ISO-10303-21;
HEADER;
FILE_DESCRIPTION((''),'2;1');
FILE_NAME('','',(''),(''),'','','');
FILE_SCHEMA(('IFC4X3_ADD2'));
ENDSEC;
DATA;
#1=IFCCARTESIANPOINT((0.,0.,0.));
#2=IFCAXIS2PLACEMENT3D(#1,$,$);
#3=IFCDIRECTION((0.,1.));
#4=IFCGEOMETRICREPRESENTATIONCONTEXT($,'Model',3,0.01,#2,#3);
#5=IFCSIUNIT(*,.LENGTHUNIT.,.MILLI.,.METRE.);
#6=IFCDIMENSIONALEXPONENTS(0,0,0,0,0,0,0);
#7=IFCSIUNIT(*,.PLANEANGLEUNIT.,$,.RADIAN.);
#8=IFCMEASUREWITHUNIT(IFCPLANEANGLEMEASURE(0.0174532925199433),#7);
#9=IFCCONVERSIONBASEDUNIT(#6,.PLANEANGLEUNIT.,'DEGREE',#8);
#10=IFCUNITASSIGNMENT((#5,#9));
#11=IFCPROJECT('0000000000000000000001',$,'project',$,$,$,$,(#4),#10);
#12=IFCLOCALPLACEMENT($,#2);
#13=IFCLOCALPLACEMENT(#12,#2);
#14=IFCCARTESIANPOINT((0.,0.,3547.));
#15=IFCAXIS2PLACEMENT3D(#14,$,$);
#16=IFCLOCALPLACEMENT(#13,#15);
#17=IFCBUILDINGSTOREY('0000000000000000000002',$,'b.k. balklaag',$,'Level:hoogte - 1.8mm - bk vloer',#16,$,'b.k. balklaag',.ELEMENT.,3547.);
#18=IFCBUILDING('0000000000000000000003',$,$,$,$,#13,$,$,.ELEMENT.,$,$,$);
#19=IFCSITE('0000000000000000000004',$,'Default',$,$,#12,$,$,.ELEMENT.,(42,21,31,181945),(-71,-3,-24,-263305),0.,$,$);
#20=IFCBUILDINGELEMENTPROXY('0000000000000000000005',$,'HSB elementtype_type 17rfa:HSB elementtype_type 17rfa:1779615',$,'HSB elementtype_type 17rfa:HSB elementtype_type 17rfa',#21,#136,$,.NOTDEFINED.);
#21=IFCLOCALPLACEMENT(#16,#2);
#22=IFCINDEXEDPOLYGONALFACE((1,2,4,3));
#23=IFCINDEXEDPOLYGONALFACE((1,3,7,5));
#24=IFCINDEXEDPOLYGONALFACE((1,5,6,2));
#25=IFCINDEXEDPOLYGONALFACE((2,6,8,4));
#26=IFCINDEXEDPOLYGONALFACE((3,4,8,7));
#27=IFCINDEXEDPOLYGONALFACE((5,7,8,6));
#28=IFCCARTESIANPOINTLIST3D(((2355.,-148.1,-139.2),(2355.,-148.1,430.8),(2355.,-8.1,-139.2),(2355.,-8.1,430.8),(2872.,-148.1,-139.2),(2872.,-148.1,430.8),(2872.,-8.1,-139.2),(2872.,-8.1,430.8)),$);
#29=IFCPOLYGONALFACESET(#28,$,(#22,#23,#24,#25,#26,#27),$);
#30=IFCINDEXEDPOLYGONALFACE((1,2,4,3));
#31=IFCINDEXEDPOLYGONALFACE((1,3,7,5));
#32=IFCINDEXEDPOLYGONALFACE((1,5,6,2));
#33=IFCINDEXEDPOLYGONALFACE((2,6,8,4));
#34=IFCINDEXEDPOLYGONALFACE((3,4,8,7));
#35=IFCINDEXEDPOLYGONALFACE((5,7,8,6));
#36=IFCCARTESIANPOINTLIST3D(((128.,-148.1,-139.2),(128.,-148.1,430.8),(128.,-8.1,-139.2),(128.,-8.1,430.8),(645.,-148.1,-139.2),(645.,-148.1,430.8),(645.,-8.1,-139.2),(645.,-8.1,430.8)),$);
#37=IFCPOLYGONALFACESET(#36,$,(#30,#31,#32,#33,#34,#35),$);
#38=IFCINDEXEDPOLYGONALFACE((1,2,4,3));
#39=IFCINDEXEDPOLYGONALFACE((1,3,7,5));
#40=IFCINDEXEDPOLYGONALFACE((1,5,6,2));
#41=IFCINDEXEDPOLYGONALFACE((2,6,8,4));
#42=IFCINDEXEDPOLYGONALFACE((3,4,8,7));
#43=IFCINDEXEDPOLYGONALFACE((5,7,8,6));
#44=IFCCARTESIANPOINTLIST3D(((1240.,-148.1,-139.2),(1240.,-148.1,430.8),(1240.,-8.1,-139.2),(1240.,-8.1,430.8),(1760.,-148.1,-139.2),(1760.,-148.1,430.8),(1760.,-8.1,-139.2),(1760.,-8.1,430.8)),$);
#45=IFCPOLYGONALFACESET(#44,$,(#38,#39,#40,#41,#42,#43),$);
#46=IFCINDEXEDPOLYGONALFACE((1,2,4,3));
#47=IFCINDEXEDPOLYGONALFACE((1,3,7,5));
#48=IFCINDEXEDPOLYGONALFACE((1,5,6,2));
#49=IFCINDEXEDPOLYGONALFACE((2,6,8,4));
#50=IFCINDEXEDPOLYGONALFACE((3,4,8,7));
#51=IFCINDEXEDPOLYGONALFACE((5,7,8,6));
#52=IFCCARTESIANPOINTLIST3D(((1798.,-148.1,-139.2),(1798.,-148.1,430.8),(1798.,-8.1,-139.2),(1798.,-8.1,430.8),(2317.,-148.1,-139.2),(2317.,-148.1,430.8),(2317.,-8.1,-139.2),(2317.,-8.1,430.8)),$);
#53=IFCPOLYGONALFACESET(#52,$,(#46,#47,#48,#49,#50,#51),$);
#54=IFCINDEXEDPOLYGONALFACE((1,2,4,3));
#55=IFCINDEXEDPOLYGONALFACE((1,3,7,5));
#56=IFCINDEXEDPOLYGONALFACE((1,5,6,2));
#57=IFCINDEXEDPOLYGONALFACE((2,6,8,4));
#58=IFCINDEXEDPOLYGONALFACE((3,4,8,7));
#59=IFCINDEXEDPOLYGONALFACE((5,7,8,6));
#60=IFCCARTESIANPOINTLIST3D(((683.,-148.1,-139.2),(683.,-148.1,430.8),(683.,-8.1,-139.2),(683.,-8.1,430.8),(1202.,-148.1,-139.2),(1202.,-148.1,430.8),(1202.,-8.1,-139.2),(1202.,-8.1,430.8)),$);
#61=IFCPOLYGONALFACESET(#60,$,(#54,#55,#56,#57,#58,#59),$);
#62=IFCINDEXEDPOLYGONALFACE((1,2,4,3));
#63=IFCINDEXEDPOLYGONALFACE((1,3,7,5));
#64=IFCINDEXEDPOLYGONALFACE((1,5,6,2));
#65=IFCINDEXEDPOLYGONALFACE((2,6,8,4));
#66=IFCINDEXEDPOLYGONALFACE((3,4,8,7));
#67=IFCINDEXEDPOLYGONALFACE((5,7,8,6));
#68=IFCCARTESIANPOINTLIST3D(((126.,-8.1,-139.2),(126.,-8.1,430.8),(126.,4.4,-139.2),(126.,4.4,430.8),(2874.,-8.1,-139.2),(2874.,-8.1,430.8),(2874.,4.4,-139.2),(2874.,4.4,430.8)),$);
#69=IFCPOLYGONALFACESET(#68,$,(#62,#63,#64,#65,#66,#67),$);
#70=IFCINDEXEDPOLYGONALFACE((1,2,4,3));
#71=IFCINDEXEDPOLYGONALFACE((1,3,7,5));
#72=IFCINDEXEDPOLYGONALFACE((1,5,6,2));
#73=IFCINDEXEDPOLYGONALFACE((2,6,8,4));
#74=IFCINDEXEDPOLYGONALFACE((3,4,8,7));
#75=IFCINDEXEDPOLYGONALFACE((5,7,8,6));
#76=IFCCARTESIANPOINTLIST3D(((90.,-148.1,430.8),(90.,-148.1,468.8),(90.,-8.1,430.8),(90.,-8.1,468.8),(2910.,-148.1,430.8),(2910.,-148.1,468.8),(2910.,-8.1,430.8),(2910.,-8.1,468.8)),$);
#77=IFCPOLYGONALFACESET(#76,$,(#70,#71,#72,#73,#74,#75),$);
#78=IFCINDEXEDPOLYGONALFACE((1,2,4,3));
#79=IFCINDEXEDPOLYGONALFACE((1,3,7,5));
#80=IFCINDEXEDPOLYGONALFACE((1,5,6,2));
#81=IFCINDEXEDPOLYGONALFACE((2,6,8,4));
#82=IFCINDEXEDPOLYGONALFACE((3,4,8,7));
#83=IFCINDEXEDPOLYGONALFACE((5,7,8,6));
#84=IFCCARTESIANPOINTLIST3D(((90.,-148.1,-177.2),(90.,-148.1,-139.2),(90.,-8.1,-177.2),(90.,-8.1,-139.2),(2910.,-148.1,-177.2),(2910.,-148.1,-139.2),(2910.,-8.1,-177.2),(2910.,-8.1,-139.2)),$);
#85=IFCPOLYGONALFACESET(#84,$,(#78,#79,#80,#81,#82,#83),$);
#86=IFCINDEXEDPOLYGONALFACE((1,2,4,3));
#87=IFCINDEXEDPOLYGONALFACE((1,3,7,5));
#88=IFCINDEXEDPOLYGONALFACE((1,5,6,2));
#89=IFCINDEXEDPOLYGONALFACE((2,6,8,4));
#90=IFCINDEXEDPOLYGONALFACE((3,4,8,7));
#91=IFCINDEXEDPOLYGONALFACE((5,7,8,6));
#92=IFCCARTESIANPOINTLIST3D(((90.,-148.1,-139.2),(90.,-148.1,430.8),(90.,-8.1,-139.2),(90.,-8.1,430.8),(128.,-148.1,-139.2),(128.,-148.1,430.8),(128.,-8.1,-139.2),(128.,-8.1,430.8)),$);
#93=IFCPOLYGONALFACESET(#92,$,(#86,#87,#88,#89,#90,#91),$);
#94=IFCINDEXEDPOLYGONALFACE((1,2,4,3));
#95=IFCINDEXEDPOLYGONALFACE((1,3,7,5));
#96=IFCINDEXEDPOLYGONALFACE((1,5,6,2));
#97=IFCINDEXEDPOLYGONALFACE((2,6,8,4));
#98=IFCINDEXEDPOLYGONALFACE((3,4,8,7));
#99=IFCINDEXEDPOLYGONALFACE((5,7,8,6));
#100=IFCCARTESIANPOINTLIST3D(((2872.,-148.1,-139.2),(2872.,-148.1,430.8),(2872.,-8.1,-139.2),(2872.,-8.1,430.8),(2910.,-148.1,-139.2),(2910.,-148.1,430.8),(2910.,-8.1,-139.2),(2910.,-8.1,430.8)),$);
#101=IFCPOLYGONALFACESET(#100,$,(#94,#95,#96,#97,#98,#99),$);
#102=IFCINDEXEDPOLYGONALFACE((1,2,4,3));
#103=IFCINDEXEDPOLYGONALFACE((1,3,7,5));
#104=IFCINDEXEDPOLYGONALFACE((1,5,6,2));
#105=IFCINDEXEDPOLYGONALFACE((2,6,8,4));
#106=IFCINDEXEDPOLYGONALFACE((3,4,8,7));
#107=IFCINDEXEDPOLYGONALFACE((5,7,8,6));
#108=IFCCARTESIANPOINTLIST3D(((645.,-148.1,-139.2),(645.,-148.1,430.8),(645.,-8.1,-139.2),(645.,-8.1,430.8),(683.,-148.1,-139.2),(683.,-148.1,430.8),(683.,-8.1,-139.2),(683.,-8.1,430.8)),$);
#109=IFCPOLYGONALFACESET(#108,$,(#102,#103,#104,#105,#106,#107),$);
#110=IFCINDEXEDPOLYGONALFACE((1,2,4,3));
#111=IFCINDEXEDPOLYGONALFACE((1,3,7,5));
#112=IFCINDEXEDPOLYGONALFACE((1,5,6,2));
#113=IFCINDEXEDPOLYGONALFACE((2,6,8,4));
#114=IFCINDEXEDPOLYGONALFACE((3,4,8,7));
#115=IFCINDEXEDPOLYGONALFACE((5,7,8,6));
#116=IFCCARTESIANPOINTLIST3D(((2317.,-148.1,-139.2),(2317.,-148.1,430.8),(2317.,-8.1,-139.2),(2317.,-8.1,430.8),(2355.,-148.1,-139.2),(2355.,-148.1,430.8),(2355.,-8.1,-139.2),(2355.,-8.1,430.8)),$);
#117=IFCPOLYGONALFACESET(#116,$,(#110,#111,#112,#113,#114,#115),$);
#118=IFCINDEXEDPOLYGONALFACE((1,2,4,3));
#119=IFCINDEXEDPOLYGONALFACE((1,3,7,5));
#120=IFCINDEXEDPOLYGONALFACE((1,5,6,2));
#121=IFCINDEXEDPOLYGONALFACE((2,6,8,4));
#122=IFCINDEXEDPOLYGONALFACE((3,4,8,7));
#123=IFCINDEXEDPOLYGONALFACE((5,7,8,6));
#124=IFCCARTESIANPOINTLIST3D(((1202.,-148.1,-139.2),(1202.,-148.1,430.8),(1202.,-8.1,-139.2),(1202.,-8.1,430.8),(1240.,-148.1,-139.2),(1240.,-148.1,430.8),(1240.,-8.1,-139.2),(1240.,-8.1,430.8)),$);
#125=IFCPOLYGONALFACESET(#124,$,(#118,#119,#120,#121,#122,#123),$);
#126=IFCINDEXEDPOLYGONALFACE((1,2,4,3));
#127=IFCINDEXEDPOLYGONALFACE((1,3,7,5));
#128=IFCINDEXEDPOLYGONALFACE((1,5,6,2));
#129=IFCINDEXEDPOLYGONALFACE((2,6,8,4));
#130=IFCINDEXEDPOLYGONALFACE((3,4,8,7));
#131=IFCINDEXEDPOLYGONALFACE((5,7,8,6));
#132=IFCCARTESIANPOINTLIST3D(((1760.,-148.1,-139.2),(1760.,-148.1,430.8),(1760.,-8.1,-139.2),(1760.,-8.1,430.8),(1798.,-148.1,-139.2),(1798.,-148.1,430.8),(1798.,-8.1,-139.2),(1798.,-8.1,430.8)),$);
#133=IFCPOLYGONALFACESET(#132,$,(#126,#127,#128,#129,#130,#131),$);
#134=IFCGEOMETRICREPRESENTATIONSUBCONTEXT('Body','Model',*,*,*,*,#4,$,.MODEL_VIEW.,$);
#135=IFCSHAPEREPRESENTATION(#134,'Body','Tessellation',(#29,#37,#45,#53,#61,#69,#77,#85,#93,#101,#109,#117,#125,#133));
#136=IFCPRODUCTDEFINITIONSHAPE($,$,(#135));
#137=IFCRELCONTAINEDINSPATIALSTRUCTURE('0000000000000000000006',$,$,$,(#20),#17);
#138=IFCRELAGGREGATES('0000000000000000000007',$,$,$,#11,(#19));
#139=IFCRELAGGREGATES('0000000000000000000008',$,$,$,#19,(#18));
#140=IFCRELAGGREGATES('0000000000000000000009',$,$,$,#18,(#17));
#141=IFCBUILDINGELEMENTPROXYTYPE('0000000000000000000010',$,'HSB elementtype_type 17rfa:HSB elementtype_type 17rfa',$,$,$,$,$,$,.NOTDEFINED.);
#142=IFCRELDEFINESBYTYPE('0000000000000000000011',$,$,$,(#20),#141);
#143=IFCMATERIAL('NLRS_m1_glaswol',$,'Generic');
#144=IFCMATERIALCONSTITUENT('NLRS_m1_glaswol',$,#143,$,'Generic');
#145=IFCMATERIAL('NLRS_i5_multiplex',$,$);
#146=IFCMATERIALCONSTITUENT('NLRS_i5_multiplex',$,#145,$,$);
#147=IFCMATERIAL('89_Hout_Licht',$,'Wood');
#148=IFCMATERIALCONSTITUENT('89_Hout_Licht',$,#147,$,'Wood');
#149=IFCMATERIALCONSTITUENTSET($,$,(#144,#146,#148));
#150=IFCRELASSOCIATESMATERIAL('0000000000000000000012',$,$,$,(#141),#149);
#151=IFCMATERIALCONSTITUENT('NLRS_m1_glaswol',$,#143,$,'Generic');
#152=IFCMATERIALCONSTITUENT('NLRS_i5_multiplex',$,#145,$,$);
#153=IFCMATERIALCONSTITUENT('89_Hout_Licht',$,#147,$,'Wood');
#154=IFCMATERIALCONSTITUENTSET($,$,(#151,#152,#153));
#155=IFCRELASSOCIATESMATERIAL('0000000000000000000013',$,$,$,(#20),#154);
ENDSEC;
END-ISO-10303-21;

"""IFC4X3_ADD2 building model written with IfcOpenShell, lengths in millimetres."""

from ifc_helpers import new_model, entity, si_unit, converted_unit, direction, frame, frame_2d, origin, origin_2d_with_axis, place, context, subcontext, project, spatial, rectangle, extrude, source, transform, mapped, material, constituent, constituent_set, type_object, type_shapes, element, save


model = new_model("IFC4X3_ADD2")

# Units and contexts
model_context = context("Model", 3, precision=0.01, world=origin(), true_north=direction((0.0, 1.0)))
body_context = subcontext(model_context, "Body", "Model", "MODEL_VIEW")
ifc_project = project(units=[si_unit("LENGTHUNIT", "METRE", prefix="MILLI"), converted_unit("PLANEANGLEUNIT", "DEGREE", entity("IfcPlaneAngleMeasure", 0.0174532925199433), si_unit("PLANEANGLEUNIT", "RADIAN"), dimensions=[0, 0, 0, 0, 0, 0, 0])], contexts=[model_context])

# Site, building, storey
site_placement = place(None, origin())
site = spatial("IfcSite", under=ifc_project, at=site_placement, Name="Default", CompositionType="ELEMENT", RefLatitude=(42, 21, 31, 181945), RefLongitude=(-71, -3, -24, -263305), RefElevation=0.0)
building_placement = place(site_placement, origin())
building = spatial("IfcBuilding", under=site, at=building_placement, CompositionType="ELEMENT")
storey_placement = place(building_placement, frame((0.0, 0.0, 3547.0)))
storey = spatial("IfcBuildingStorey", under=building, at=storey_placement, Name="b.k. balklaag", ObjectType="Level:hoogte - 1.8mm - bk vloer", LongName="b.k. balklaag", CompositionType="ELEMENT", Elevation=3547.0)

# Shared definitions
ifc_material_1 = material(Name="89_Hout_Licht", Category="Wood")

# Building element proxy
ifc_material_2 = material(Name="NLRS_m1_glaswol", Category="Generic")
ifc_material_3 = material(Name="NLRS_i5_multiplex")
ifc_constituent_1 = constituent(ifc_material_2, Name="NLRS_m1_glaswol", Category="Generic")
ifc_constituent_2 = constituent(ifc_material_3, Name="NLRS_i5_multiplex")
ifc_constituent_3 = constituent(ifc_material_1, Name="89_Hout_Licht", Category="Wood")
ifc_constituent_set_1 = constituent_set(constituents=[ifc_constituent_1, ifc_constituent_2, ifc_constituent_3])
ifc_constituent_4 = constituent(ifc_material_2, Name="NLRS_m1_glaswol", Category="Generic")
ifc_constituent_5 = constituent(ifc_material_3, Name="NLRS_i5_multiplex")
ifc_constituent_6 = constituent(ifc_material_1, Name="89_Hout_Licht", Category="Wood")
ifc_constituent_set_2 = constituent_set(constituents=[ifc_constituent_4, ifc_constituent_5, ifc_constituent_6])
building_element_proxy_type_1 = type_object("IfcBuildingElementProxyType", Name="HSB elementtype_type 17rfa:HSB elementtype_type 17rfa", PredefinedType="NOTDEFINED", material=ifc_constituent_set_2)
shared_shape_1 = source(origin(), body_context, "Body", "SweptSolid", [
    extrude(rectangle(XDim=517.0, YDim=140.0, at=frame_2d((0.0, 0.0), x_axis=(1.0, 0.0))), frame((-1149.5, 70.0, 38.0), z_axis=(0.0, 0.0, 1.0), x_axis=(-1.0, 0.0, 0.0)), (0.0, 0.0, 1.0), 570.0),
    extrude(rectangle(XDim=517.0, YDim=140.0, at=frame_2d((0.0, 0.0), x_axis=(1.0, 0.0))), frame((1077.5, 70.0, 38.0), z_axis=(0.0, 0.0, 1.0), x_axis=(-1.0, 0.0, 0.0)), (0.0, 0.0, 1.0), 570.0),
    extrude(rectangle(XDim=520.0, YDim=140.0, at=origin_2d_with_axis()), frame((-36.0, 70.0, 38.0), z_axis=(0.0, 0.0, 1.0), x_axis=(-1.0, 0.0, 0.0)), (0.0, 0.0, 1.0), 570.0),
    extrude(rectangle(XDim=519.0, YDim=140.0, at=origin_2d_with_axis()), frame((-593.5, 70.0, 38.0), z_axis=(0.0, 0.0, 1.0), x_axis=(-1.0, 0.0, 0.0)), (0.0, 0.0, 1.0), 570.0),
    extrude(rectangle(XDim=519.0, YDim=140.0, at=origin_2d_with_axis()), frame((521.5, 70.0, 38.0), z_axis=(0.0, 0.0, 1.0), x_axis=(-1.0, 0.0, 0.0)), (0.0, 0.0, 1.0), 570.0),
    extrude(rectangle(XDim=2748.0, YDim=12.5, at=frame_2d((0.0, 0.0), x_axis=(1.0, 0.0))), frame((-36.0, -6.2, 38.0), z_axis=(0.0, 0.0, 1.0), x_axis=(-1.0, 0.0, 0.0)), (0.0, 0.0, 1.0), 570.0),
    extrude(rectangle(XDim=2820.0, YDim=140.0, at=frame_2d((0.0, 0.0), x_axis=(1.0, 0.0))), frame((-36.0, 70.0, 608.0), z_axis=(0.0, 0.0, 1.0), x_axis=(-1.0, 0.0, 0.0)), (0.0, 0.0, 1.0), 38.0),
    extrude(rectangle(XDim=2820.0, YDim=140.0, at=origin_2d_with_axis()), frame((-36.0, 70.0, 0.0), z_axis=(0.0, 0.0, 1.0), x_axis=(-1.0, 0.0, 0.0)), (0.0, 0.0, 1.0), 38.0),
    extrude(rectangle(XDim=38.0, YDim=140.0, at=frame_2d((0.0, 0.0), x_axis=(1.0, 0.0))), frame((1355.0, 70.0, 38.0), z_axis=(0.0, 0.0, 1.0), x_axis=(-1.0, 0.0, 0.0)), (0.0, 0.0, 1.0), 570.0),
    extrude(rectangle(XDim=38.0, YDim=140.0, at=frame_2d((0.0, 0.0), x_axis=(1.0, 0.0))), frame((-1427.0, 70.0, 38.0), z_axis=(0.0, 0.0, 1.0), x_axis=(-1.0, 0.0, 0.0)), (0.0, 0.0, 1.0), 570.0),
    extrude(rectangle(XDim=38.0, YDim=140.0, at=origin_2d_with_axis()), frame((800.0, 70.0, 38.0), z_axis=(0.0, 0.0, 1.0), x_axis=(-1.0, 0.0, 0.0)), (0.0, 0.0, 1.0), 570.0),
    extrude(rectangle(XDim=38.0, YDim=140.0, at=frame_2d((0.0, 0.0), x_axis=(1.0, 0.0))), frame((-872.0, 70.0, 38.0), z_axis=(0.0, 0.0, 1.0), x_axis=(-1.0, 0.0, 0.0)), (0.0, 0.0, 1.0), 570.0),
    extrude(rectangle(XDim=38.0, YDim=140.0, at=origin_2d_with_axis()), frame((243.0, 70.0, 38.0), z_axis=(0.0, 0.0, 1.0), x_axis=(-1.0, 0.0, 0.0)), (0.0, 0.0, 1.0), 570.0),
    extrude(rectangle(XDim=38.0, YDim=140.0, at=frame_2d((0.0, 0.0), x_axis=(1.0, 0.0))), frame((-315.0, 70.0, 38.0), z_axis=(0.0, 0.0, 1.0), x_axis=(-1.0, 0.0, 0.0)), (0.0, 0.0, 1.0), 570.0),
])
type_shapes(building_element_proxy_type_1, [shared_shape_1])
proxy_1_placement = place(storey_placement, frame((1464.0, -8.1, -177.2), z_axis=(0.0, 0.0, 1.0), x_axis=(-1.0, 0.0, 0.0)))
element("IfcBuildingElementProxy", 1, at=proxy_1_placement, inside=storey, type_object=building_element_proxy_type_1, material=ifc_constituent_set_1, Name="HSB elementtype_type 17rfa:HSB elementtype_type 17rfa:1779615", ObjectType="HSB elementtype_type 17rfa:HSB elementtype_type 17rfa", PredefinedType="NOTDEFINED", context=body_context, shape_type="MappedRepresentation", body=[
    mapped(shared_shape_1, transform((0.0, 0.0, 0.0), scale=1.0)),
])

save(model, "model.ifc")
